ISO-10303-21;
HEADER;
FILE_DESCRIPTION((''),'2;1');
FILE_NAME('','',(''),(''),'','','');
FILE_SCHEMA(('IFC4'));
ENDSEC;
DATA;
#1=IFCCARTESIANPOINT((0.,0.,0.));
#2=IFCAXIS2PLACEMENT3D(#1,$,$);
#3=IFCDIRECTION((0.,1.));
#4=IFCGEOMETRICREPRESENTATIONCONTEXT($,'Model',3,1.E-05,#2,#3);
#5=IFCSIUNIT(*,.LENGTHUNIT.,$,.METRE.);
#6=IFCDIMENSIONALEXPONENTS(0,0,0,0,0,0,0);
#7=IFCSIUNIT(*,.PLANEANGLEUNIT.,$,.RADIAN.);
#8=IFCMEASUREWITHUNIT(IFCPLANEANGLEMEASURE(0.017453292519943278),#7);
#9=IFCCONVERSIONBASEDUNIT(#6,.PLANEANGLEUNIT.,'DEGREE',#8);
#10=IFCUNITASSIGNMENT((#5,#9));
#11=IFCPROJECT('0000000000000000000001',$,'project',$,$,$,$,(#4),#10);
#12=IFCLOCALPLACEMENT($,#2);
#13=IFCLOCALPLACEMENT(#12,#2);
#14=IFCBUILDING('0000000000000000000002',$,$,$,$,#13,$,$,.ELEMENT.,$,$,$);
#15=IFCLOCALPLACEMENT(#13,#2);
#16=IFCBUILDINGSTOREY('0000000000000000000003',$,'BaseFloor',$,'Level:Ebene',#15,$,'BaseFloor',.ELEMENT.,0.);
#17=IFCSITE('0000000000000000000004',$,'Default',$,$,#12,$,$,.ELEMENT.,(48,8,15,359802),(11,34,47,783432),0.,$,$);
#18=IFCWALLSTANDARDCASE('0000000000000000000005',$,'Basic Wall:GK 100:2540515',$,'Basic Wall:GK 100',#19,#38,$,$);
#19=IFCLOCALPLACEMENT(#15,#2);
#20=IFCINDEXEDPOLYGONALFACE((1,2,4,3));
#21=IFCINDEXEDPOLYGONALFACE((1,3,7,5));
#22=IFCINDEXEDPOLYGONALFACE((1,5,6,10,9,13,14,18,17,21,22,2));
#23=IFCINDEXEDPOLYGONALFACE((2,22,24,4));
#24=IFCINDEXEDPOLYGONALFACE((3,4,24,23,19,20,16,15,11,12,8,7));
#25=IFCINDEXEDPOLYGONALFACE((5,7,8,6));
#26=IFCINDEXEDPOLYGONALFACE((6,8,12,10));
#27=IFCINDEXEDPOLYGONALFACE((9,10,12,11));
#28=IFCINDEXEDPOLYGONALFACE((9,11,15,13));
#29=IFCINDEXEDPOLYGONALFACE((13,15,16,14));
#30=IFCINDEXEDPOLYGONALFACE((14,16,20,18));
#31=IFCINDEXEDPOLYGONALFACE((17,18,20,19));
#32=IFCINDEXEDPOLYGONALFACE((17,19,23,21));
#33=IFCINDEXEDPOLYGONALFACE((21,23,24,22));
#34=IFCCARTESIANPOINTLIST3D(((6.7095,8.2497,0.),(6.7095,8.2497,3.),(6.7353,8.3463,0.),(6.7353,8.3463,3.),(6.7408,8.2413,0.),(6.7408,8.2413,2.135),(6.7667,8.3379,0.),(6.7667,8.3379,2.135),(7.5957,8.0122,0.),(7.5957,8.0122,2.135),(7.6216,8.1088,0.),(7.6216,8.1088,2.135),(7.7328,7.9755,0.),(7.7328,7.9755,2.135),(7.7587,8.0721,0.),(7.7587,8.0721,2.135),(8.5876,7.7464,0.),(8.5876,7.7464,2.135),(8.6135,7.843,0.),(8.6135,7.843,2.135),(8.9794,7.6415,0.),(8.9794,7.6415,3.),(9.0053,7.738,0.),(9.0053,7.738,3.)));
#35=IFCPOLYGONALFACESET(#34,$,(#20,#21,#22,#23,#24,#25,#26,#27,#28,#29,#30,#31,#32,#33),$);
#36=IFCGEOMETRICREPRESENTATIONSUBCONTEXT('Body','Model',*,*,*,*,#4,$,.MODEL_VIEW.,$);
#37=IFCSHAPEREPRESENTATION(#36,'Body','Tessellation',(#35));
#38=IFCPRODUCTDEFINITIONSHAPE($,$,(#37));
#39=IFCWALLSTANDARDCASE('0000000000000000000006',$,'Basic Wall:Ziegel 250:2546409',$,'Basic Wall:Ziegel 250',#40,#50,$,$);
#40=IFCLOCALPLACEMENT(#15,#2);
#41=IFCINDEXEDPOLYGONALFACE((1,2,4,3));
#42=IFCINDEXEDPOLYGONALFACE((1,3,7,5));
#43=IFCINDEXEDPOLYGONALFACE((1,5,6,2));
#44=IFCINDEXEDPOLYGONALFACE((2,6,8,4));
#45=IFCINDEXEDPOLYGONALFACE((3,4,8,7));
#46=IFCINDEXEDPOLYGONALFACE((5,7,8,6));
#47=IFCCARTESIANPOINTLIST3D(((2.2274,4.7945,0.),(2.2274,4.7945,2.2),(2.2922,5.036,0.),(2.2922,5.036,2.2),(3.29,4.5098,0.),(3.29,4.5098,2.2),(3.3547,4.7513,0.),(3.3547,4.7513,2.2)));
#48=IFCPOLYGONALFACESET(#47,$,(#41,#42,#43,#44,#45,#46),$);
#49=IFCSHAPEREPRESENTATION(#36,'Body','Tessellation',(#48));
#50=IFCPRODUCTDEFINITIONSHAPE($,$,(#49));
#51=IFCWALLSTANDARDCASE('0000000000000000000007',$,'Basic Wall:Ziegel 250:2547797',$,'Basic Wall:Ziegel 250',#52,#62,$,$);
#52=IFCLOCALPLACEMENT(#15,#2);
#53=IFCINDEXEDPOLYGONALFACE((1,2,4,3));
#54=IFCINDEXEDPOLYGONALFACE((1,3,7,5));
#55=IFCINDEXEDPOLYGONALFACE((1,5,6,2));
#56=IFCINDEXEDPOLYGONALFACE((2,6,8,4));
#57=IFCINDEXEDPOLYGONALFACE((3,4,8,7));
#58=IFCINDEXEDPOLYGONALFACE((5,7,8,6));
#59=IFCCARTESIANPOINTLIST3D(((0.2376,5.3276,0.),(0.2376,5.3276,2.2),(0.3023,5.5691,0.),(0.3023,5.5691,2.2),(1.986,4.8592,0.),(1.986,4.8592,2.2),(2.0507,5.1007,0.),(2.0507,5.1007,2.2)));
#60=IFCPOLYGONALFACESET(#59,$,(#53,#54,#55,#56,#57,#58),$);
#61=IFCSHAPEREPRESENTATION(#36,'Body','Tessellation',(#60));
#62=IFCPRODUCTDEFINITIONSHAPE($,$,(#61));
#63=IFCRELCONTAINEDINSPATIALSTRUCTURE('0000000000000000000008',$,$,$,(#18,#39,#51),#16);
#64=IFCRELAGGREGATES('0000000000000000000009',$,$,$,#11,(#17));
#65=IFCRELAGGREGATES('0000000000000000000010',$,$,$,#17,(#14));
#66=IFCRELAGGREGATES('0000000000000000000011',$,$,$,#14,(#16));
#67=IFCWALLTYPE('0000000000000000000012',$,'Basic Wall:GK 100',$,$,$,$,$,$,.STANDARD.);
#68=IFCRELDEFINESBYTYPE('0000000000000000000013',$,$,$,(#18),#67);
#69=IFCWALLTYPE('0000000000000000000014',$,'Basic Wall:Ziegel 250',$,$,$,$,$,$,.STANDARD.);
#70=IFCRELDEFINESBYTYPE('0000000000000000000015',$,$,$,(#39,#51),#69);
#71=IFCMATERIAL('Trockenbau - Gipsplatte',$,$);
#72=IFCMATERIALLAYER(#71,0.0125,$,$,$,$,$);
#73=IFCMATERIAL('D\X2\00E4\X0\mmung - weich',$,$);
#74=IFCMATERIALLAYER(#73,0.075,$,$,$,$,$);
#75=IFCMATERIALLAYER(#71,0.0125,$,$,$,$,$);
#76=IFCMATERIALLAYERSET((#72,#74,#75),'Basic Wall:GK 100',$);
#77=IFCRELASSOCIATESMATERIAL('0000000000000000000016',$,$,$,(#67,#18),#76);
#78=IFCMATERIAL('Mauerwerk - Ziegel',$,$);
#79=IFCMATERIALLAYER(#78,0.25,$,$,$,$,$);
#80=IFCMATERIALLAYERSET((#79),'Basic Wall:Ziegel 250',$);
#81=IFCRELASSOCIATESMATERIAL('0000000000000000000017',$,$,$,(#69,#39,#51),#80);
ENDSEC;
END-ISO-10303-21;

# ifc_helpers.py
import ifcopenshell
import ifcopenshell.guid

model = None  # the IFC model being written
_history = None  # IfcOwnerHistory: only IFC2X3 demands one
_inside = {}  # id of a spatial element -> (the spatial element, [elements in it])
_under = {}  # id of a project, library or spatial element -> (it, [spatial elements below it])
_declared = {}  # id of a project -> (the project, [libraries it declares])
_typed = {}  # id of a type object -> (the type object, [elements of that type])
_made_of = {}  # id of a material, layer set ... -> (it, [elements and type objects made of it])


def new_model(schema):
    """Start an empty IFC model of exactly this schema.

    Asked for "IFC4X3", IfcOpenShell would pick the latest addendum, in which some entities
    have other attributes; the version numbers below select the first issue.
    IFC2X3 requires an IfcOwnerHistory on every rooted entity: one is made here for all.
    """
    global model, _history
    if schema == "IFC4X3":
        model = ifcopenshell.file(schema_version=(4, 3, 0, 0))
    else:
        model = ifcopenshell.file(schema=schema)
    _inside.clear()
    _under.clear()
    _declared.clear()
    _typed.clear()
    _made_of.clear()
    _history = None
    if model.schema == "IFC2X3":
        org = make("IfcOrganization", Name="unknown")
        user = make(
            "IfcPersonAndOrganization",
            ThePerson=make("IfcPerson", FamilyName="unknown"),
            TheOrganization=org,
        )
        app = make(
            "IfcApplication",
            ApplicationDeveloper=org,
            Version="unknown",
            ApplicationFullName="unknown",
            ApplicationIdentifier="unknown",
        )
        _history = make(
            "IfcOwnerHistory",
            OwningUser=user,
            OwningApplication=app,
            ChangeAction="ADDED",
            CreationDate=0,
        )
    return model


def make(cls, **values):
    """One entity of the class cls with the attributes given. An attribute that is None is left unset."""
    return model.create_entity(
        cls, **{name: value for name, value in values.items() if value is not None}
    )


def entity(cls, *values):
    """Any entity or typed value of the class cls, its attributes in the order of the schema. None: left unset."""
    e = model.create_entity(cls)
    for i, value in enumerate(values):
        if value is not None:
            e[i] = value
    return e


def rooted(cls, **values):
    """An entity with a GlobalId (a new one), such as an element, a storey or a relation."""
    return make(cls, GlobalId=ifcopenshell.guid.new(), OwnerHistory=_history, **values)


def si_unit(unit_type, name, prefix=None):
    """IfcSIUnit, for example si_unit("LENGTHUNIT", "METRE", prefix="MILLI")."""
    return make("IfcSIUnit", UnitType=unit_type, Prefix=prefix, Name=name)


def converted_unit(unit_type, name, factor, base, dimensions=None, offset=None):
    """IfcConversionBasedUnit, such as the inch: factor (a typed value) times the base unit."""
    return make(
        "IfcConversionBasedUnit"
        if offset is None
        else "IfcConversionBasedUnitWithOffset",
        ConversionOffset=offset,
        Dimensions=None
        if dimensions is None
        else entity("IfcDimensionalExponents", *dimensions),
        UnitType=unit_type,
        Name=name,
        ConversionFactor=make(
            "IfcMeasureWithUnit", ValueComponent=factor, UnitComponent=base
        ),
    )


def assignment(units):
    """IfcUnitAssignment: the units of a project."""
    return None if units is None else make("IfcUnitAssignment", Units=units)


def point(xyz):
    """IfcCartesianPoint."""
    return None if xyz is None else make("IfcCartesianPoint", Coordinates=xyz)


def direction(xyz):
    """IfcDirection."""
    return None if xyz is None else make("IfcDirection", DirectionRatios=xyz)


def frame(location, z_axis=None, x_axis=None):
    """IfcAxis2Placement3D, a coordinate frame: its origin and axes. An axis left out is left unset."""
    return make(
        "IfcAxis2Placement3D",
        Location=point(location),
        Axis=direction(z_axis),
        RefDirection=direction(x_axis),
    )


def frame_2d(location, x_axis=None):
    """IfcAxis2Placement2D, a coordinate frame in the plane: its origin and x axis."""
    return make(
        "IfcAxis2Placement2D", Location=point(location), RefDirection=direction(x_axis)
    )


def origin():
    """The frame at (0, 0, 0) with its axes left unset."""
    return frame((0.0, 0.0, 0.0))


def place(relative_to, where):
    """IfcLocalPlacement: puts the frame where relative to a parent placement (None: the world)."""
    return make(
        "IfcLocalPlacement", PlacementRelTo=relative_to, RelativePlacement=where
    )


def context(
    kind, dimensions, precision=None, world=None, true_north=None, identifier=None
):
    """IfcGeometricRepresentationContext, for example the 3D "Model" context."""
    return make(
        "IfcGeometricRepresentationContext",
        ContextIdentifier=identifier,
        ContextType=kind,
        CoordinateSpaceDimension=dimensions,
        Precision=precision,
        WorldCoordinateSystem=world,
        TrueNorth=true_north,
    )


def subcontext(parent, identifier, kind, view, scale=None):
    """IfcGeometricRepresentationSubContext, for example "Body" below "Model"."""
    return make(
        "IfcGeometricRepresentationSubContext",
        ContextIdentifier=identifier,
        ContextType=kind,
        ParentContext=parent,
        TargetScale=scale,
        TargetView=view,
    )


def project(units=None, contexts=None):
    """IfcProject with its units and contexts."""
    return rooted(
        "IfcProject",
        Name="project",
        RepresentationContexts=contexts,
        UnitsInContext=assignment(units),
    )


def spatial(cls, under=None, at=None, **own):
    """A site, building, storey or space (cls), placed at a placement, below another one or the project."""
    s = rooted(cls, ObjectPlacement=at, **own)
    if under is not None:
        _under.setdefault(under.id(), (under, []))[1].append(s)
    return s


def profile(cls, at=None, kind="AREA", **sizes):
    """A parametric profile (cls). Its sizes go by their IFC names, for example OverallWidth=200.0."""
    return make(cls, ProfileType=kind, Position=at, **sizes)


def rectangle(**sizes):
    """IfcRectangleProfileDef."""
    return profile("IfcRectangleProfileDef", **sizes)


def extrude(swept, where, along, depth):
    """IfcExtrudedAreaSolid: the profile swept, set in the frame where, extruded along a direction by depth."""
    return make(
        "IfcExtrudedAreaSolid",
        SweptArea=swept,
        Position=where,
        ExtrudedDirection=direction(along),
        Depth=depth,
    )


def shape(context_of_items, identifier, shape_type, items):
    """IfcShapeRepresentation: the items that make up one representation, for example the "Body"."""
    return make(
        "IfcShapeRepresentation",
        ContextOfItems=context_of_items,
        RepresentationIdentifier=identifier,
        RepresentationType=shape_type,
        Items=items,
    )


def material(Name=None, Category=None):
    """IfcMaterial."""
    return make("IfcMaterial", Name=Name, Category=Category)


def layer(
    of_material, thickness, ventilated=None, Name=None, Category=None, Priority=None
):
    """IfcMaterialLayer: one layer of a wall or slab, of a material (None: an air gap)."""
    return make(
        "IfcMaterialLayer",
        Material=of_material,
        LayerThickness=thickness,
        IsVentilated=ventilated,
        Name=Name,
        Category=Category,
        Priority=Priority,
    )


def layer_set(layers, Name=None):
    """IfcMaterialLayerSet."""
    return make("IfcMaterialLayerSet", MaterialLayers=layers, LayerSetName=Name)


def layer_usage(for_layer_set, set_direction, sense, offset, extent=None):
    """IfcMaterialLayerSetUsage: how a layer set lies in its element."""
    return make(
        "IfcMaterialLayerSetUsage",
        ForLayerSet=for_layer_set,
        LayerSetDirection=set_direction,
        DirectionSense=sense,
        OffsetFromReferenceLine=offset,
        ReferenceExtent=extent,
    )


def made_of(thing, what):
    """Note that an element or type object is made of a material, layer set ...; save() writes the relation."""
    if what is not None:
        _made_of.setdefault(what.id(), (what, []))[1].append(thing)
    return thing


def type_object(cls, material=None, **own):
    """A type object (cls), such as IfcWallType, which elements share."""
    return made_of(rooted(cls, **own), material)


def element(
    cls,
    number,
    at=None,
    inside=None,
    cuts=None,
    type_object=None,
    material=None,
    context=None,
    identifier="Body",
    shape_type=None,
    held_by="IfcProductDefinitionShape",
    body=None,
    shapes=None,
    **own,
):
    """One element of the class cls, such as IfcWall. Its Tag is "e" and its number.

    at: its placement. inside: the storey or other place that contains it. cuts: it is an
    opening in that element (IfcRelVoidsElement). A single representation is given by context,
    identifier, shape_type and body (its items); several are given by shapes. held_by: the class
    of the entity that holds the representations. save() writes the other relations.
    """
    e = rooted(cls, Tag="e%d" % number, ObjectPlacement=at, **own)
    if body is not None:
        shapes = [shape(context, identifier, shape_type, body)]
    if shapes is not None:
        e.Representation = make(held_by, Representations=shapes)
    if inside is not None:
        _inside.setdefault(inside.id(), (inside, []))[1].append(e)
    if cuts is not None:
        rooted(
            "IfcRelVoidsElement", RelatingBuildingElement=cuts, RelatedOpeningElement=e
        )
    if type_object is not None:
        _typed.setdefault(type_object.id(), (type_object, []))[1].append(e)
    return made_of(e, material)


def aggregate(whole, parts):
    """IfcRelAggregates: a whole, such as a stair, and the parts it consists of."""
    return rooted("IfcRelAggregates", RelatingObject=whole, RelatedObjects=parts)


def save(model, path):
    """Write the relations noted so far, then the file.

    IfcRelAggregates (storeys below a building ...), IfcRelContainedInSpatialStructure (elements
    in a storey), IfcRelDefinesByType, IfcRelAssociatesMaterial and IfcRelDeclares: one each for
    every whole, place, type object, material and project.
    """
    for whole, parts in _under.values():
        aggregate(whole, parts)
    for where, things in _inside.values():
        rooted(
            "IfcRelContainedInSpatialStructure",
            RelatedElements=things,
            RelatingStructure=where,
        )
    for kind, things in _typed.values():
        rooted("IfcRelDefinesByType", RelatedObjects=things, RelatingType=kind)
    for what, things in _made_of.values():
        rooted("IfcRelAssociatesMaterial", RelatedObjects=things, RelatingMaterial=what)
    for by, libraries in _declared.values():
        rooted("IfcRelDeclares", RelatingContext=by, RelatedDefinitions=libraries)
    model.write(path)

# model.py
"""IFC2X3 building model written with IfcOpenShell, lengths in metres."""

from ifc_helpers import new_model, entity, si_unit, converted_unit, direction, frame, frame_2d, origin, place, context, subcontext, project, spatial, rectangle, extrude, material, layer, layer_set, layer_usage, type_object, element, save


model = new_model("IFC2X3")

# Units and contexts
model_context = context("Model", 3, precision=1e-05, world=origin(), true_north=direction((0.0, 1.0)))
body_context = subcontext(model_context, "Body", "Model", "MODEL_VIEW")
ifc_project = project(units=[si_unit("LENGTHUNIT", "METRE"), converted_unit("PLANEANGLEUNIT", "DEGREE", entity("IfcPlaneAngleMeasure", 0.017453292519943278), si_unit("PLANEANGLEUNIT", "RADIAN"), dimensions=[0, 0, 0, 0, 0, 0, 0])], contexts=[model_context])

# Site, building, storey
site_placement = place(None, origin())
site = spatial("IfcSite", under=ifc_project, at=site_placement, Name="Default", CompositionType="ELEMENT", RefLatitude=(48, 8, 15, 359802), RefLongitude=(11, 34, 47, 783432), RefElevation=0.0)
building_placement = place(site_placement, origin())
building = spatial("IfcBuilding", under=site, at=building_placement, CompositionType="ELEMENT")
storey_placement = place(building_placement, origin())
storey = spatial("IfcBuildingStorey", under=building, at=storey_placement, Name="BaseFloor", ObjectType="Level:Ebene", LongName="BaseFloor", CompositionType="ELEMENT", Elevation=0.0)

# Shared definitions
ifc_material_1 = material(Name="Mauerwerk - Ziegel")

# Shared definitions
ifc_material_2 = material(Name="Trockenbau - Gipsplatte")
ifc_material_3 = material(Name="Dämmung - weich")

# Shared definitions
ifc_layer_1 = layer(ifc_material_2, 0.0125)
ifc_layer_2 = layer(ifc_material_3, 0.075)
ifc_layer_3 = layer(ifc_material_2, 0.0125)
ifc_layer_set_1 = layer_set([ifc_layer_1, ifc_layer_2, ifc_layer_3], Name="Basic Wall:GK 100")
wall_type_1 = type_object("IfcWallType", Name="Basic Wall:GK 100", PredefinedType="STANDARD", material=ifc_layer_set_1)

# Wall, openings
ifc_layer_usage_1 = layer_usage(ifc_layer_set_1, "AXIS2", "NEGATIVE", 0.05)
wall_1_placement = place(storey_placement, frame((8.9923, 7.6898, 0.0), z_axis=(0.0, 0.0, 1.0), x_axis=(-0.965926, 0.258819, 0.0)))
wall_1 = element("IfcWallStandardCase", 1, at=wall_1_placement, inside=storey, type_object=wall_type_1, material=ifc_layer_usage_1, Name="Basic Wall:GK 100:2540515", ObjectType="Basic Wall:GK 100", context=body_context, shape_type="SweptSolid", body=[
    extrude(rectangle(XDim=2.35, YDim=0.1, at=frame_2d((1.175, 0.0), x_axis=(1.0, 0.0))), origin(), (0.0, 0.0, 1.0), 3.0),
])
opening_1_placement = place(wall_1_placement, frame((1.4325, -0.05, -0.18)))
element("IfcOpeningElement", 2, at=opening_1_placement, cuts=wall_1, ObjectType="Opening", context=body_context, shape_type="SweptSolid", body=[
    extrude(rectangle(XDim=2.315, YDim=0.885, at=frame_2d((1.1575, 0.4425), x_axis=(-1.0, 0.0))), frame((0.0, 0.0, 0.0), z_axis=(0.0, 1.0, 0.0), x_axis=(0.0, 0.0, 1.0)), (0.0, 0.0, 1.0), 0.1),
])
opening_2_placement = place(wall_1_placement, frame((0.4056, -0.05, -0.18)))
element("IfcOpeningElement", 3, at=opening_2_placement, cuts=wall_1, ObjectType="Opening", context=body_context, shape_type="SweptSolid", body=[
    extrude(rectangle(XDim=2.315, YDim=0.885, at=frame_2d((1.1575, 0.4425), x_axis=(-1.0, 0.0))), frame((0.0, 0.0, 0.0), z_axis=(0.0, 1.0, 0.0), x_axis=(0.0, 0.0, 1.0)), (0.0, 0.0, 1.0), 0.1),
])

# Walls
ifc_layer_4 = layer(ifc_material_1, 0.25)
ifc_layer_set_2 = layer_set([ifc_layer_4], Name="Basic Wall:Ziegel 250")
ifc_layer_usage_2 = layer_usage(ifc_layer_set_2, "AXIS2", "NEGATIVE", 0.125)
wall_type_2 = type_object("IfcWallType", Name="Basic Wall:Ziegel 250", PredefinedType="STANDARD", material=ifc_layer_set_2)
wall_2_placement = place(storey_placement, frame((3.3223, 4.6305, 0.0), z_axis=(0.0, 0.0, 1.0), x_axis=(-0.965926, 0.258819, 0.0)))
element("IfcWallStandardCase", 4, at=wall_2_placement, inside=storey, type_object=wall_type_2, material=ifc_layer_usage_2, Name="Basic Wall:Ziegel 250:2546409", ObjectType="Basic Wall:Ziegel 250", context=body_context, shape_type="SweptSolid", body=[
    extrude(rectangle(XDim=1.1, YDim=0.25, at=frame_2d((0.55, 0.0), x_axis=(-1.0, 0.0))), origin(), (0.0, 0.0, 1.0), 2.2),
])
ifc_layer_usage_3 = layer_usage(ifc_layer_set_2, "AXIS2", "NEGATIVE", 0.125)
wall_3_placement = place(storey_placement, frame((2.0183, 4.9799, 0.0), z_axis=(0.0, 0.0, 1.0), x_axis=(-0.965926, 0.258819, 0.0)))
element("IfcWallStandardCase", 5, at=wall_3_placement, inside=storey, type_object=wall_type_2, material=ifc_layer_usage_3, Name="Basic Wall:Ziegel 250:2547797", ObjectType="Basic Wall:Ziegel 250", context=body_context, shape_type="SweptSolid", body=[
    extrude(rectangle(XDim=1.81, YDim=0.25, at=frame_2d((0.905, 0.0), x_axis=(-1.0, 0.0))), origin(), (0.0, 0.0, 1.0), 2.2),
])

save(model, "model.ifc")
